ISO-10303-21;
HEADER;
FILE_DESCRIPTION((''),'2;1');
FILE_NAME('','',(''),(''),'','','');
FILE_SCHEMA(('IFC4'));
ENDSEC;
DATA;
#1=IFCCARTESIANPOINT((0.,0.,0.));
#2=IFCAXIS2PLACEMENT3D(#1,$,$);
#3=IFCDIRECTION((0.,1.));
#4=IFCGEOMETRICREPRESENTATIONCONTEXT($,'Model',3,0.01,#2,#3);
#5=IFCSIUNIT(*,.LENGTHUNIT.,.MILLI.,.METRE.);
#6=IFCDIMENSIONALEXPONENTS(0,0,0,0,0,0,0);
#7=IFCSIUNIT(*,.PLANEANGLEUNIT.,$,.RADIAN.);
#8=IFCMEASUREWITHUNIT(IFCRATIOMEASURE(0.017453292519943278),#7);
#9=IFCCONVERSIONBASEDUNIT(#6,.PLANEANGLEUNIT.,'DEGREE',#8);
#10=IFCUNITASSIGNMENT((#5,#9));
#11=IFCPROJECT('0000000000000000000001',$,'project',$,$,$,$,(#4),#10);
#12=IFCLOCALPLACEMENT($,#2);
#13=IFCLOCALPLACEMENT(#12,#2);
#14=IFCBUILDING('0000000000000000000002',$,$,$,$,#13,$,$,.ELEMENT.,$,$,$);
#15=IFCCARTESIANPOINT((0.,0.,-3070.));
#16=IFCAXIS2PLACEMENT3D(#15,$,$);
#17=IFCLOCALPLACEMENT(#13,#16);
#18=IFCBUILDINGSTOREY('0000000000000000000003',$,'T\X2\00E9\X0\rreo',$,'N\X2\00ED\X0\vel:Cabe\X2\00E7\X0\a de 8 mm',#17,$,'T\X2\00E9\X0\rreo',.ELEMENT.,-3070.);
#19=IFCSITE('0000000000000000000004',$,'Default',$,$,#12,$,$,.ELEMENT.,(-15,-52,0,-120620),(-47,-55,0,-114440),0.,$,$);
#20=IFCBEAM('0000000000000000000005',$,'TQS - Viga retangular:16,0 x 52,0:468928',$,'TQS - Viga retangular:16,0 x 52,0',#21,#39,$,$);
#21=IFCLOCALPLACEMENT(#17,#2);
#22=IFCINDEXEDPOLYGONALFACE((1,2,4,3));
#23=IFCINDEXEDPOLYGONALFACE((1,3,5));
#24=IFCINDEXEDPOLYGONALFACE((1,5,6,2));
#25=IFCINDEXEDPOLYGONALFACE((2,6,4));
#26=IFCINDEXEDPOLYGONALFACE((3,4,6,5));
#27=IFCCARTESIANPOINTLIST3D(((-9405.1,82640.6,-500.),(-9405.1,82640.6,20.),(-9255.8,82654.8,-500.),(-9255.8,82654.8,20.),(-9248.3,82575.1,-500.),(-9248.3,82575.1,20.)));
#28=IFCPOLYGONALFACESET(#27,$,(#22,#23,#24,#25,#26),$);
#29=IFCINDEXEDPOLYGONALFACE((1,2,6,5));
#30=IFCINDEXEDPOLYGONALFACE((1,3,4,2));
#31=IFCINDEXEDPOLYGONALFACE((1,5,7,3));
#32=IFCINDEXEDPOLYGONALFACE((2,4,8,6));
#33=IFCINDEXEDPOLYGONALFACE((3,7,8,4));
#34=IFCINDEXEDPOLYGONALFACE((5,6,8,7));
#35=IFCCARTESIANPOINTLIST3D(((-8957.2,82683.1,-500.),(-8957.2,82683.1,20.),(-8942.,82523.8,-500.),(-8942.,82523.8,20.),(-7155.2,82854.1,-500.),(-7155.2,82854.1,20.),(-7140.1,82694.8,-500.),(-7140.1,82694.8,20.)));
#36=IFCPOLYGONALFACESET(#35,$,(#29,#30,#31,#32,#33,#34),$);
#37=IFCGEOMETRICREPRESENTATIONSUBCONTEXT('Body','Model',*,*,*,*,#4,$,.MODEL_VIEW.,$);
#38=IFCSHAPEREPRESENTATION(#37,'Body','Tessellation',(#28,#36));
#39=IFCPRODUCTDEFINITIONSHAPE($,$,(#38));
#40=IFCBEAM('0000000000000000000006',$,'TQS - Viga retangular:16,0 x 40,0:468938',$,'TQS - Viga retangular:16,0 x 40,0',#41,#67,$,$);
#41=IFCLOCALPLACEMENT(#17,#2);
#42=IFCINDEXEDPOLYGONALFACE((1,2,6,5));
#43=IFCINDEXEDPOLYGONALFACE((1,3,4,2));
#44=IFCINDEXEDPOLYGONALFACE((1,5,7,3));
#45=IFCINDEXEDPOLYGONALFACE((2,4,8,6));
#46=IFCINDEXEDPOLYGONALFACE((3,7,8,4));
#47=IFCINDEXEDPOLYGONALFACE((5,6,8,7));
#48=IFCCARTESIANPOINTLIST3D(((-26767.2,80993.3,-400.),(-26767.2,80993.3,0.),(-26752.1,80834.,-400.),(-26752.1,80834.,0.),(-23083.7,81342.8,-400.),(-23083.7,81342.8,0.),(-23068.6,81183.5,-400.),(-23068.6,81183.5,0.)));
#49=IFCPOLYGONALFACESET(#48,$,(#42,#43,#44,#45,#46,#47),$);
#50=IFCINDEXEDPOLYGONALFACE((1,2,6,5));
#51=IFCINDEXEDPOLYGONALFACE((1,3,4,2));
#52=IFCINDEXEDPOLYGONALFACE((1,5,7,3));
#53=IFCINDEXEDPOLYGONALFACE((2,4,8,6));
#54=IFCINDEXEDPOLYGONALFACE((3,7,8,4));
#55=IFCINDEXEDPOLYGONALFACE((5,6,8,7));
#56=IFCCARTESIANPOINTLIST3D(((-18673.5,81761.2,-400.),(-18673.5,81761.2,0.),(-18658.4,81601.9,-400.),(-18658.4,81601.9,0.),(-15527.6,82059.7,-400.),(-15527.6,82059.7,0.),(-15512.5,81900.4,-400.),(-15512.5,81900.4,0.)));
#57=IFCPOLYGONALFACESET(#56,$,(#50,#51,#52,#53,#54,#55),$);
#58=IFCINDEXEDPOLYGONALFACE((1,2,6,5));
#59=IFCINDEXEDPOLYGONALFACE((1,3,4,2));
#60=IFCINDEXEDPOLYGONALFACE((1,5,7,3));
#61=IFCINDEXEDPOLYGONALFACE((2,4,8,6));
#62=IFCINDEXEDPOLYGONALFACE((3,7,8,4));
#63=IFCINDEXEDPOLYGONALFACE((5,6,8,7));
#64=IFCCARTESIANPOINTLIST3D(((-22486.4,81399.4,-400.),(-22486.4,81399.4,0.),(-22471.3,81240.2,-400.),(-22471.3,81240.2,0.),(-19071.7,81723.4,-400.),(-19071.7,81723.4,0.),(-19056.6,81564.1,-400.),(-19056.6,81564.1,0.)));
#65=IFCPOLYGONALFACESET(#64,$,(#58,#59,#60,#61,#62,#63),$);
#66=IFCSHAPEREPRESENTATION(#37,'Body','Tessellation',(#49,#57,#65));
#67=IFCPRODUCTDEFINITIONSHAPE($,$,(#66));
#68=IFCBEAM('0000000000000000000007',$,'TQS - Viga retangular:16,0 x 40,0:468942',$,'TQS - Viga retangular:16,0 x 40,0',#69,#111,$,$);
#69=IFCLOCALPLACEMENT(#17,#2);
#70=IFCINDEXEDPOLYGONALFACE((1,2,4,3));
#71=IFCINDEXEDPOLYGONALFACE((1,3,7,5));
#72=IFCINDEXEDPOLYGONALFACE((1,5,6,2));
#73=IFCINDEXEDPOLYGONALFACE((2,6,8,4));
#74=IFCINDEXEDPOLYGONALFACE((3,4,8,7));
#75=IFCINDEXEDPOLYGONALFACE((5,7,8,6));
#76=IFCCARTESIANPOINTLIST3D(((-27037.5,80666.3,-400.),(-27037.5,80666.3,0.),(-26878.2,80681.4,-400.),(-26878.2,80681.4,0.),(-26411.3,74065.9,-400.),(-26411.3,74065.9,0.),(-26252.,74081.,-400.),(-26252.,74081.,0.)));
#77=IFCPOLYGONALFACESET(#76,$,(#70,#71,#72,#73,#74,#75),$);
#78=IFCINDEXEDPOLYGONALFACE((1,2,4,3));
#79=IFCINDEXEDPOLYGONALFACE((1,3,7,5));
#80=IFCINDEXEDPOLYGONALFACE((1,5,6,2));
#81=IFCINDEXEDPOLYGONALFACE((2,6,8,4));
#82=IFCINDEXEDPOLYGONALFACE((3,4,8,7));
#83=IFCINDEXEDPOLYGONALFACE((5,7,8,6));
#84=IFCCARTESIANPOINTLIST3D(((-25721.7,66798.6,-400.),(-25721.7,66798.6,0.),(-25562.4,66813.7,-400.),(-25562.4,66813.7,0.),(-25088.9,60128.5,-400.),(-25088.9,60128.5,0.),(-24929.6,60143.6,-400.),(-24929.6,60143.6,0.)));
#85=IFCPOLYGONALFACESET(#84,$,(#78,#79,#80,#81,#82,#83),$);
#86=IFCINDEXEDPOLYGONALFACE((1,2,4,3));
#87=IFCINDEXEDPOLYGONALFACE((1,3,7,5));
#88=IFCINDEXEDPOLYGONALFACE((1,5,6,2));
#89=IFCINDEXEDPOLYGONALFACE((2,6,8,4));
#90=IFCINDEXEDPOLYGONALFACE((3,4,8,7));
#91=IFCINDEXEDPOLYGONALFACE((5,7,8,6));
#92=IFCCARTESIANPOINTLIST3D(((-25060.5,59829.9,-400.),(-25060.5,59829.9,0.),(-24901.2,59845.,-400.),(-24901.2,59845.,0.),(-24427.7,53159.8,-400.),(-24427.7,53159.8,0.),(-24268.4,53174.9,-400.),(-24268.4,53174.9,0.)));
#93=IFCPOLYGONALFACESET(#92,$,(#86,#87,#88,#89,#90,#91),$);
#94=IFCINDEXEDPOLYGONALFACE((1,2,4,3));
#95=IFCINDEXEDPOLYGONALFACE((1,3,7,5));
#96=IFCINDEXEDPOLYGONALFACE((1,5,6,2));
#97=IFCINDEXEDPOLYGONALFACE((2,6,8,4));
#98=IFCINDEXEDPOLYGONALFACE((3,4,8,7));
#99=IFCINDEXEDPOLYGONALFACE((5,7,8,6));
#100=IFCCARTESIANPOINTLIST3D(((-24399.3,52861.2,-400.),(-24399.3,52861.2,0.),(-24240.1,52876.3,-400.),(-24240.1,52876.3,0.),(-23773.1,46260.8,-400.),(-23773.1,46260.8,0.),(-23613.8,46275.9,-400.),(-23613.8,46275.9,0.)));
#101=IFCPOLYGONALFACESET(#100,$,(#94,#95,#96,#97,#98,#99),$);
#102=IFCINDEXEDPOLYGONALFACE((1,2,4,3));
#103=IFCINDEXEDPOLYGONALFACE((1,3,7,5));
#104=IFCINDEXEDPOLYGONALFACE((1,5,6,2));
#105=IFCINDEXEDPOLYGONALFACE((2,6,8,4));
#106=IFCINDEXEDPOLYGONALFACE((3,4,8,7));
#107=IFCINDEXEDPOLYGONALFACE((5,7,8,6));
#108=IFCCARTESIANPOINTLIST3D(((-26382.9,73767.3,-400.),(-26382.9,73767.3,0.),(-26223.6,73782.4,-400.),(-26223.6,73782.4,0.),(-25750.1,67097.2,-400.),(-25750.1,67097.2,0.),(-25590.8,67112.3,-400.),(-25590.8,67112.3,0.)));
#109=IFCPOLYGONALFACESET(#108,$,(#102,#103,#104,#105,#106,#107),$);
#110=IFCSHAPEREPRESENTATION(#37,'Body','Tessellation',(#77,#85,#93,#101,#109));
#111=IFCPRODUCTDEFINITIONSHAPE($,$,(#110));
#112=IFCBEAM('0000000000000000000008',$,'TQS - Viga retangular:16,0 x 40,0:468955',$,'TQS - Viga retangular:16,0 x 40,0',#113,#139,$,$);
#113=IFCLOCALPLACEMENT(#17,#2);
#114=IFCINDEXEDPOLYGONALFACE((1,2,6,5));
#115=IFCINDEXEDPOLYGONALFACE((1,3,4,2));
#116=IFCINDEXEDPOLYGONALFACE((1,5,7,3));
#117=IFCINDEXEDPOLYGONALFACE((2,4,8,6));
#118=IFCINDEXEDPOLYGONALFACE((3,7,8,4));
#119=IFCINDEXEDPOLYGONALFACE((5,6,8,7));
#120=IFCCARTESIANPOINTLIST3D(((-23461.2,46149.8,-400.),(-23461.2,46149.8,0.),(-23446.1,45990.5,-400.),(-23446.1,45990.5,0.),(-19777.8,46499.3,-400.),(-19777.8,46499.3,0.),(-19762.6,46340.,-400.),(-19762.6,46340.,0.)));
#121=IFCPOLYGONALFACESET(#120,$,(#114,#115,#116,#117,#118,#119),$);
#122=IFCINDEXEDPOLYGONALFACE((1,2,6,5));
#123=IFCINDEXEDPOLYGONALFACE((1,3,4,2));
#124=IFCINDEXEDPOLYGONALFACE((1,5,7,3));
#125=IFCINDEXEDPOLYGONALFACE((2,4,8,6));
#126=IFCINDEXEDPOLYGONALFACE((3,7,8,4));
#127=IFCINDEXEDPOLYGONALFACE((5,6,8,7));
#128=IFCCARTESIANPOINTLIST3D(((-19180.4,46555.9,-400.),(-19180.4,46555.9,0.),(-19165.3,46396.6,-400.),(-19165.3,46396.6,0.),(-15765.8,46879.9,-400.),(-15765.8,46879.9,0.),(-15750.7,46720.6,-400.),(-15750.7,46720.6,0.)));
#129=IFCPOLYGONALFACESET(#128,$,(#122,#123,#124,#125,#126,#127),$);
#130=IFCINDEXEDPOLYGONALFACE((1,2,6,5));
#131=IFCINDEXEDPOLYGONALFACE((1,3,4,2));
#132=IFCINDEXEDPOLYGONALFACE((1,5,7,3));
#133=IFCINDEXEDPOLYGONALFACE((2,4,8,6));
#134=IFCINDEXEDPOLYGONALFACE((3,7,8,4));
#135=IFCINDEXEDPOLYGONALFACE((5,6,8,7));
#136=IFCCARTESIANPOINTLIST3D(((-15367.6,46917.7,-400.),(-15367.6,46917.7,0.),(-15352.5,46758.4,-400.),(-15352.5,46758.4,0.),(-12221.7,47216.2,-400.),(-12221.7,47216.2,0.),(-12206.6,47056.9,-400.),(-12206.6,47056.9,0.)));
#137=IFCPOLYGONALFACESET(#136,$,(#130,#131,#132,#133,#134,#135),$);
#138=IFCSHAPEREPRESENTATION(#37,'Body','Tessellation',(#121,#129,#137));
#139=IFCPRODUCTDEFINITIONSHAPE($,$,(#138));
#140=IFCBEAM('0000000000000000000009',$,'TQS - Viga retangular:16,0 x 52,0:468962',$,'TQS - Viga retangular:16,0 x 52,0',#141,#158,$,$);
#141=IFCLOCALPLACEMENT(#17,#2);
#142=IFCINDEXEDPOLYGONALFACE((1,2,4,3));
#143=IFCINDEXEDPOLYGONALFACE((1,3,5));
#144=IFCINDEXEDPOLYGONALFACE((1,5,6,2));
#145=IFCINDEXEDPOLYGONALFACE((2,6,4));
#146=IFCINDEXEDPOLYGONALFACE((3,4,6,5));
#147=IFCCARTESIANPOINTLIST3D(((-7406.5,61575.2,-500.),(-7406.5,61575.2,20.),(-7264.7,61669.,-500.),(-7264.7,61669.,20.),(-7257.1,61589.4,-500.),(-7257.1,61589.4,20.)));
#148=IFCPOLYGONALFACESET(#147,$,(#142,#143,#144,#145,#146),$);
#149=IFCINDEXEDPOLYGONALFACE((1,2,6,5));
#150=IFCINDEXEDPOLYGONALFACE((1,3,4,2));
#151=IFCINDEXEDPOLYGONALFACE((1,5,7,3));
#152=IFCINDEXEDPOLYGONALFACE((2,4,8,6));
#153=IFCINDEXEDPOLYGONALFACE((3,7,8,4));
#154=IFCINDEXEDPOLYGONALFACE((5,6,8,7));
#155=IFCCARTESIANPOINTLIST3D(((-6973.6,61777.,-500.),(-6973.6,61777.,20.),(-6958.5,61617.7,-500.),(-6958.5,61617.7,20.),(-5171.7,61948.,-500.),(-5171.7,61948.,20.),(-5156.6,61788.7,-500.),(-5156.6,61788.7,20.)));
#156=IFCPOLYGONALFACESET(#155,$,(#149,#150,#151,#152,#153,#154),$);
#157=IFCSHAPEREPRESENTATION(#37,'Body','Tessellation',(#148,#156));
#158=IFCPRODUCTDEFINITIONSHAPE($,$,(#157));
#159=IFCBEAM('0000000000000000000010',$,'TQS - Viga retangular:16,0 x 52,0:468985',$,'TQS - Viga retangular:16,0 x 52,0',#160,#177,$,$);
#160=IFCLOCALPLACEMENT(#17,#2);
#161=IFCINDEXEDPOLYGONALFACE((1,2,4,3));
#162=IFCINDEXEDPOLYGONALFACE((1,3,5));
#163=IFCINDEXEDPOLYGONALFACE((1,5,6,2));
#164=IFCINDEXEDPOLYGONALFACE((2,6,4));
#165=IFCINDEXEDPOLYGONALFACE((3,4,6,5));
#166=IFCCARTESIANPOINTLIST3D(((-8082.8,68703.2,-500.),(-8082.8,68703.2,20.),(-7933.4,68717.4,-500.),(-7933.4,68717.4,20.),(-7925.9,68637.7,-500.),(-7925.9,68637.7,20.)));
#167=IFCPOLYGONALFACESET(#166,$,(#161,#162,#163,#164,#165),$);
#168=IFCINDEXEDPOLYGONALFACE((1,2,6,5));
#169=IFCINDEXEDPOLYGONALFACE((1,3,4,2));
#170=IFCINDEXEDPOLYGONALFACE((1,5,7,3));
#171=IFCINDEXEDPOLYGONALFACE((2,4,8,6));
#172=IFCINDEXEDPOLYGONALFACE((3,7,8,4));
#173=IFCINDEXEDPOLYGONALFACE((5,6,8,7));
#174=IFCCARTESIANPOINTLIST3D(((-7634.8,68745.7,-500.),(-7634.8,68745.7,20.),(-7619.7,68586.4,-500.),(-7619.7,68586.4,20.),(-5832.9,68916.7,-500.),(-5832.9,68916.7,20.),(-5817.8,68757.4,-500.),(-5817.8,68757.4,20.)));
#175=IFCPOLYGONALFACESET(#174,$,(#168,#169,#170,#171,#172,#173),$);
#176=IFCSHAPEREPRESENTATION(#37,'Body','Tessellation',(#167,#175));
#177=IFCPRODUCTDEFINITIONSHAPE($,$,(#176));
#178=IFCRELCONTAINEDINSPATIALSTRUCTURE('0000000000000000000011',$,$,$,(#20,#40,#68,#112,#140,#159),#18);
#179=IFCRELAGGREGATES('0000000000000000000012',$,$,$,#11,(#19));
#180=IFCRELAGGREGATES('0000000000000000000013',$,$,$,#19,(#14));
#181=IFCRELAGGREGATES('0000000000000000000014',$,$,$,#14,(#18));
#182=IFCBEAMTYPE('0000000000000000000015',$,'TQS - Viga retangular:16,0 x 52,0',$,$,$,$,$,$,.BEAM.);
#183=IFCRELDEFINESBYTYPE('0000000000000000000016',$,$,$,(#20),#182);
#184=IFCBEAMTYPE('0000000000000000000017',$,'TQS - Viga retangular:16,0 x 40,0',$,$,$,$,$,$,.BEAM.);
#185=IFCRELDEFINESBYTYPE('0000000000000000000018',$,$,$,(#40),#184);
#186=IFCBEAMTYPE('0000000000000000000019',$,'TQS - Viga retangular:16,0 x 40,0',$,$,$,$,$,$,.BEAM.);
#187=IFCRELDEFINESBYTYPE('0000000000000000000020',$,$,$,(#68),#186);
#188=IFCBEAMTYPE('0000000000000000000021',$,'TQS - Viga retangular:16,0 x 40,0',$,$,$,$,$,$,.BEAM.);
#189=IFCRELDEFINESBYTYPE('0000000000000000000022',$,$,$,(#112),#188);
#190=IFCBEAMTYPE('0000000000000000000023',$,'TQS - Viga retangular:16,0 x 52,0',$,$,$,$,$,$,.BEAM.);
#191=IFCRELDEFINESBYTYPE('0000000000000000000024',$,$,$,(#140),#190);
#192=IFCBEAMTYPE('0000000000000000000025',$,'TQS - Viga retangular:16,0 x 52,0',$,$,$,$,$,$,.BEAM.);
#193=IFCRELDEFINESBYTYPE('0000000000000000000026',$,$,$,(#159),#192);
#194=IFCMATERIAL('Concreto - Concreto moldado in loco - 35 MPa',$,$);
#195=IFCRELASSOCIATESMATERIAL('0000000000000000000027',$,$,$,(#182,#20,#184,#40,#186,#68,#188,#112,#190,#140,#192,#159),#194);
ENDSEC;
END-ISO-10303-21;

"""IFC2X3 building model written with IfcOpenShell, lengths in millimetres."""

from ifc_helpers import new_model, entity, si_unit, converted_unit, direction, frame, frame_2d, origin, origin_2d_with_axis, place, context, subcontext, project, spatial, rectangle, extrude, clip, halfspace, source, transform, mapped, material, type_object, type_shapes, element, save


model = new_model("IFC2X3")

# Units and contexts
model_context = context("Model", 3, precision=0.01, world=origin(), true_north=direction((0.0, 1.0)))
body_context = subcontext(model_context, "Body", "Model", "MODEL_VIEW")
ifc_project = project(units=[si_unit("LENGTHUNIT", "METRE", prefix="MILLI"), converted_unit("PLANEANGLEUNIT", "DEGREE", entity("IfcRatioMeasure", 0.017453292519943278), si_unit("PLANEANGLEUNIT", "RADIAN"), dimensions=[0, 0, 0, 0, 0, 0, 0])], contexts=[model_context])

# Site, building, storey
site_placement = place(None, origin())
site = spatial("IfcSite", under=ifc_project, at=site_placement, Name="Default", CompositionType="ELEMENT", RefLatitude=(-15, -52, 0, -120620), RefLongitude=(-47, -55, 0, -114440), RefElevation=0.0)
building_placement = place(site_placement, origin())
building = spatial("IfcBuilding", under=site, at=building_placement, CompositionType="ELEMENT")
storey_placement = place(building_placement, frame((0.0, 0.0, -3070.0)))
storey = spatial("IfcBuildingStorey", under=building, at=storey_placement, Name="Térreo", ObjectType="Nível:Cabeça de 8 mm", LongName="Térreo", CompositionType="ELEMENT", Elevation=-3070.0)

# Shared definitions
ifc_material = material(Name="Concreto - Concreto moldado in loco - 35 MPa")

# Beams
beam_type_1 = type_object("IfcBeamType", Name="TQS - Viga retangular:16,0 x 52,0", PredefinedType="BEAM", material=ifc_material)
shared_shape_1 = source(origin(), body_context, "Body", "SweptSolid", [
    clip(extrude(rectangle(XDim=520.0, YDim=80.0, at=origin_2d_with_axis()), frame((-9252.0, 82614.9, -3310.0), z_axis=(-0.995529, -0.094456, 0.0), x_axis=(0.0, 0.0, -1.0)), (0.0, 0.0, 1.0), 150.0), halfspace(frame((-9091.4, 82509.6, -3050.0), z_axis=(-0.385141, -0.922858, 0.0), x_axis=(0.922858, -0.385141, 0.0)), False)),
    extrude(rectangle(XDim=520.0, YDim=160.0, at=frame_2d((0.0, 0.0), x_axis=(1.0, 0.0))), frame((-7147.7, 82774.4, -3310.0), z_axis=(-0.995529, -0.094456, 0.0), x_axis=(0.0, 0.0, -1.0)), (0.0, 0.0, 1.0), 1810.0),
])
type_shapes(beam_type_1, [shared_shape_1])
beam_1_placement = place(storey_placement, frame((0.0, 0.0, 3070.0)))
element("IfcBeam", 1, at=beam_1_placement, inside=storey, type_object=beam_type_1, material=ifc_material, Name="TQS - Viga retangular:16,0 x 52,0:468928", ObjectType="TQS - Viga retangular:16,0 x 52,0", context=body_context, shape_type="MappedRepresentation", body=[
    mapped(shared_shape_1, transform((0.0, 0.0, 0.0), scale=1.0)),
])
beam_type_2 = type_object("IfcBeamType", Name="TQS - Viga retangular:16,0 x 40,0", PredefinedType="BEAM", material=ifc_material)
shared_shape_2 = source(origin(), body_context, "Body", "SweptSolid", [
    extrude(rectangle(XDim=400.0, YDim=160.0, at=origin_2d_with_axis()), frame((-23076.2, 81263.1, -3270.0), z_axis=(-0.995529, -0.094456, 0.0), x_axis=(0.0, 0.0, -1.0)), (0.0, 0.0, 1.0), 3700.0),
    extrude(rectangle(XDim=400.0, YDim=160.0, at=frame_2d((0.0, 0.0), x_axis=(1.0, 0.0))), frame((-15520.1, 81980.1, -3270.0), z_axis=(-0.995529, -0.094456, 0.0), x_axis=(0.0, 0.0, -1.0)), (0.0, 0.0, 1.0), 3160.0),
    extrude(rectangle(XDim=400.0, YDim=160.0, at=frame_2d((0.0, 0.0), x_axis=(1.0, 0.0))), frame((-19064.2, 81643.8, -3270.0), z_axis=(-0.995529, -0.094456, 0.0), x_axis=(0.0, 0.0, -1.0)), (0.0, 0.0, 1.0), 3430.0),
])
type_shapes(beam_type_2, [shared_shape_2])
beam_2_placement = place(storey_placement, frame((0.0, 0.0, 3070.0)))
element("IfcBeam", 2, at=beam_2_placement, inside=storey, type_object=beam_type_2, material=ifc_material, Name="TQS - Viga retangular:16,0 x 40,0:468938", ObjectType="TQS - Viga retangular:16,0 x 40,0", context=body_context, shape_type="MappedRepresentation", body=[
    mapped(shared_shape_2, transform((0.0, 0.0, 0.0), scale=1.0)),
])
beam_type_3 = type_object("IfcBeamType", Name="TQS - Viga retangular:16,0 x 40,0", PredefinedType="BEAM", material=ifc_material)
shared_shape_3 = source(origin(), body_context, "Body", "SweptSolid", [
    extrude(rectangle(XDim=400.0, YDim=160.0, at=frame_2d((0.0, 0.0), x_axis=(1.0, 0.0))), frame((-26331.6, 74073.5, -3270.0), z_axis=(-0.094456, 0.995529, 0.0), x_axis=(0.0, 0.0, 1.0)), (0.0, 0.0, 1.0), 6630.0),
    extrude(rectangle(XDim=400.0, YDim=160.0, at=frame_2d((0.0, 0.0), x_axis=(1.0, 0.0))), frame((-25009.2, 60136.1, -3270.0), z_axis=(-0.094456, 0.995529, 0.0), x_axis=(0.0, 0.0, 1.0)), (0.0, 0.0, 1.0), 6700.0),
    extrude(rectangle(XDim=400.0, YDim=160.0, at=origin_2d_with_axis()), frame((-24348.0, 53167.4, -3270.0), z_axis=(-0.094456, 0.995529, 0.0), x_axis=(0.0, 0.0, 1.0)), (0.0, 0.0, 1.0), 6700.0),
    extrude(rectangle(XDim=400.0, YDim=160.0, at=frame_2d((0.0, 0.0), x_axis=(1.0, 0.0))), frame((-23693.5, 46268.4, -3270.0), z_axis=(-0.094456, 0.995529, 0.0), x_axis=(0.0, 0.0, 1.0)), (0.0, 0.0, 1.0), 6630.0),
    extrude(rectangle(XDim=400.0, YDim=160.0, at=frame_2d((0.0, 0.0), x_axis=(1.0, 0.0))), frame((-25670.4, 67104.8, -3270.0), z_axis=(-0.094456, 0.995529, 0.0), x_axis=(0.0, 0.0, 1.0)), (0.0, 0.0, 1.0), 6700.0),
])
type_shapes(beam_type_3, [shared_shape_3])
beam_3_placement = place(storey_placement, frame((0.0, 0.0, 3070.0)))
element("IfcBeam", 3, at=beam_3_placement, inside=storey, type_object=beam_type_3, material=ifc_material, Name="TQS - Viga retangular:16,0 x 40,0:468942", ObjectType="TQS - Viga retangular:16,0 x 40,0", context=body_context, shape_type="MappedRepresentation", body=[
    mapped(shared_shape_3, transform((0.0, 0.0, 0.0), scale=1.0)),
])
beam_type_4 = type_object("IfcBeamType", Name="TQS - Viga retangular:16,0 x 40,0", PredefinedType="BEAM", material=ifc_material)
shared_shape_4 = source(origin(), body_context, "Body", "SweptSolid", [
    extrude(rectangle(XDim=400.0, YDim=160.0, at=frame_2d((0.0, 0.0), x_axis=(1.0, 0.0))), frame((-19770.2, 46419.6, -3270.0), z_axis=(-0.995529, -0.094456, 0.0), x_axis=(0.0, 0.0, -1.0)), (0.0, 0.0, 1.0), 3700.0),
    extrude(rectangle(XDim=400.0, YDim=160.0, at=frame_2d((0.0, 0.0), x_axis=(1.0, 0.0))), frame((-15758.2, 46800.3, -3270.0), z_axis=(-0.995529, -0.094456, 0.0), x_axis=(0.0, 0.0, -1.0)), (0.0, 0.0, 1.0), 3430.0),
    extrude(rectangle(XDim=400.0, YDim=160.0, at=frame_2d((0.0, 0.0), x_axis=(1.0, 0.0))), frame((-12214.1, 47136.5, -3270.0), z_axis=(-0.995529, -0.094456, 0.0), x_axis=(0.0, 0.0, -1.0)), (0.0, 0.0, 1.0), 3160.0),
])
type_shapes(beam_type_4, [shared_shape_4])
beam_4_placement = place(storey_placement, frame((0.0, 0.0, 3070.0)))
element("IfcBeam", 4, at=beam_4_placement, inside=storey, type_object=beam_type_4, material=ifc_material, Name="TQS - Viga retangular:16,0 x 40,0:468955", ObjectType="TQS - Viga retangular:16,0 x 40,0", context=body_context, shape_type="MappedRepresentation", body=[
    mapped(shared_shape_4, transform((0.0, 0.0, 0.0), scale=1.0)),
])
beam_type_5 = type_object("IfcBeamType", Name="TQS - Viga retangular:16,0 x 52,0", PredefinedType="BEAM", material=ifc_material)
shared_shape_5 = source(origin(), body_context, "Body", "SweptSolid", [
    clip(extrude(rectangle(XDim=520.0, YDim=80.0, at=frame_2d((0.0, 0.0), x_axis=(0.0, 1.0))), frame((-7260.9, 61629.2, -3310.0), z_axis=(-0.995529, -0.094456, 0.0), x_axis=(0.094456, -0.995529, 0.0)), (0.0, 0.0, 1.0), 150.0), halfspace(frame((-7122.9, 61762.8, -3050.0), z_axis=(-0.551828, 0.833958, 0.0), x_axis=(0.833958, 0.551828, 0.0)), False)),
    extrude(rectangle(XDim=520.0, YDim=160.0, at=origin_2d_with_axis()), frame((-5164.1, 61868.3, -3310.0), z_axis=(-0.995529, -0.094456, 0.0), x_axis=(0.0, 0.0, -1.0)), (0.0, 0.0, 1.0), 1810.0),
])
type_shapes(beam_type_5, [shared_shape_5])
beam_5_placement = place(storey_placement, frame((0.0, 0.0, 3070.0)))
element("IfcBeam", 5, at=beam_5_placement, inside=storey, type_object=beam_type_5, material=ifc_material, Name="TQS - Viga retangular:16,0 x 52,0:468962", ObjectType="TQS - Viga retangular:16,0 x 52,0", context=body_context, shape_type="MappedRepresentation", body=[
    mapped(shared_shape_5, transform((0.0, 0.0, 0.0), scale=1.0)),
])
beam_type_6 = type_object("IfcBeamType", Name="TQS - Viga retangular:16,0 x 52,0", PredefinedType="BEAM", material=ifc_material)
shared_shape_6 = source(origin(), body_context, "Body", "SweptSolid", [
    clip(extrude(rectangle(XDim=520.0, YDim=80.0, at=frame_2d((0.0, 0.0), x_axis=(1.0, 0.0))), frame((-7929.7, 68677.5, -3310.0), z_axis=(-0.995529, -0.094456, 0.0), x_axis=(0.0, 0.0, -1.0)), (0.0, 0.0, 1.0), 150.0), halfspace(frame((-7769.0, 68572.2, -3050.0), z_axis=(-0.385141, -0.922858, 0.0), x_axis=(0.922858, -0.385141, 0.0)), False)),
    extrude(rectangle(XDim=520.0, YDim=160.0, at=frame_2d((0.0, 0.0), x_axis=(1.0, 0.0))), frame((-5825.3, 68837.0, -3310.0), z_axis=(-0.995529, -0.094456, 0.0), x_axis=(0.0, 0.0, -1.0)), (0.0, 0.0, 1.0), 1810.0),
])
type_shapes(beam_type_6, [shared_shape_6])
beam_6_placement = place(storey_placement, frame((0.0, 0.0, 3070.0)))
element("IfcBeam", 6, at=beam_6_placement, inside=storey, type_object=beam_type_6, material=ifc_material, Name="TQS - Viga retangular:16,0 x 52,0:468985", ObjectType="TQS - Viga retangular:16,0 x 52,0", context=body_context, shape_type="MappedRepresentation", body=[
    mapped(shared_shape_6, transform((0.0, 0.0, 0.0), scale=1.0)),
])

save(model, "model.ifc")
